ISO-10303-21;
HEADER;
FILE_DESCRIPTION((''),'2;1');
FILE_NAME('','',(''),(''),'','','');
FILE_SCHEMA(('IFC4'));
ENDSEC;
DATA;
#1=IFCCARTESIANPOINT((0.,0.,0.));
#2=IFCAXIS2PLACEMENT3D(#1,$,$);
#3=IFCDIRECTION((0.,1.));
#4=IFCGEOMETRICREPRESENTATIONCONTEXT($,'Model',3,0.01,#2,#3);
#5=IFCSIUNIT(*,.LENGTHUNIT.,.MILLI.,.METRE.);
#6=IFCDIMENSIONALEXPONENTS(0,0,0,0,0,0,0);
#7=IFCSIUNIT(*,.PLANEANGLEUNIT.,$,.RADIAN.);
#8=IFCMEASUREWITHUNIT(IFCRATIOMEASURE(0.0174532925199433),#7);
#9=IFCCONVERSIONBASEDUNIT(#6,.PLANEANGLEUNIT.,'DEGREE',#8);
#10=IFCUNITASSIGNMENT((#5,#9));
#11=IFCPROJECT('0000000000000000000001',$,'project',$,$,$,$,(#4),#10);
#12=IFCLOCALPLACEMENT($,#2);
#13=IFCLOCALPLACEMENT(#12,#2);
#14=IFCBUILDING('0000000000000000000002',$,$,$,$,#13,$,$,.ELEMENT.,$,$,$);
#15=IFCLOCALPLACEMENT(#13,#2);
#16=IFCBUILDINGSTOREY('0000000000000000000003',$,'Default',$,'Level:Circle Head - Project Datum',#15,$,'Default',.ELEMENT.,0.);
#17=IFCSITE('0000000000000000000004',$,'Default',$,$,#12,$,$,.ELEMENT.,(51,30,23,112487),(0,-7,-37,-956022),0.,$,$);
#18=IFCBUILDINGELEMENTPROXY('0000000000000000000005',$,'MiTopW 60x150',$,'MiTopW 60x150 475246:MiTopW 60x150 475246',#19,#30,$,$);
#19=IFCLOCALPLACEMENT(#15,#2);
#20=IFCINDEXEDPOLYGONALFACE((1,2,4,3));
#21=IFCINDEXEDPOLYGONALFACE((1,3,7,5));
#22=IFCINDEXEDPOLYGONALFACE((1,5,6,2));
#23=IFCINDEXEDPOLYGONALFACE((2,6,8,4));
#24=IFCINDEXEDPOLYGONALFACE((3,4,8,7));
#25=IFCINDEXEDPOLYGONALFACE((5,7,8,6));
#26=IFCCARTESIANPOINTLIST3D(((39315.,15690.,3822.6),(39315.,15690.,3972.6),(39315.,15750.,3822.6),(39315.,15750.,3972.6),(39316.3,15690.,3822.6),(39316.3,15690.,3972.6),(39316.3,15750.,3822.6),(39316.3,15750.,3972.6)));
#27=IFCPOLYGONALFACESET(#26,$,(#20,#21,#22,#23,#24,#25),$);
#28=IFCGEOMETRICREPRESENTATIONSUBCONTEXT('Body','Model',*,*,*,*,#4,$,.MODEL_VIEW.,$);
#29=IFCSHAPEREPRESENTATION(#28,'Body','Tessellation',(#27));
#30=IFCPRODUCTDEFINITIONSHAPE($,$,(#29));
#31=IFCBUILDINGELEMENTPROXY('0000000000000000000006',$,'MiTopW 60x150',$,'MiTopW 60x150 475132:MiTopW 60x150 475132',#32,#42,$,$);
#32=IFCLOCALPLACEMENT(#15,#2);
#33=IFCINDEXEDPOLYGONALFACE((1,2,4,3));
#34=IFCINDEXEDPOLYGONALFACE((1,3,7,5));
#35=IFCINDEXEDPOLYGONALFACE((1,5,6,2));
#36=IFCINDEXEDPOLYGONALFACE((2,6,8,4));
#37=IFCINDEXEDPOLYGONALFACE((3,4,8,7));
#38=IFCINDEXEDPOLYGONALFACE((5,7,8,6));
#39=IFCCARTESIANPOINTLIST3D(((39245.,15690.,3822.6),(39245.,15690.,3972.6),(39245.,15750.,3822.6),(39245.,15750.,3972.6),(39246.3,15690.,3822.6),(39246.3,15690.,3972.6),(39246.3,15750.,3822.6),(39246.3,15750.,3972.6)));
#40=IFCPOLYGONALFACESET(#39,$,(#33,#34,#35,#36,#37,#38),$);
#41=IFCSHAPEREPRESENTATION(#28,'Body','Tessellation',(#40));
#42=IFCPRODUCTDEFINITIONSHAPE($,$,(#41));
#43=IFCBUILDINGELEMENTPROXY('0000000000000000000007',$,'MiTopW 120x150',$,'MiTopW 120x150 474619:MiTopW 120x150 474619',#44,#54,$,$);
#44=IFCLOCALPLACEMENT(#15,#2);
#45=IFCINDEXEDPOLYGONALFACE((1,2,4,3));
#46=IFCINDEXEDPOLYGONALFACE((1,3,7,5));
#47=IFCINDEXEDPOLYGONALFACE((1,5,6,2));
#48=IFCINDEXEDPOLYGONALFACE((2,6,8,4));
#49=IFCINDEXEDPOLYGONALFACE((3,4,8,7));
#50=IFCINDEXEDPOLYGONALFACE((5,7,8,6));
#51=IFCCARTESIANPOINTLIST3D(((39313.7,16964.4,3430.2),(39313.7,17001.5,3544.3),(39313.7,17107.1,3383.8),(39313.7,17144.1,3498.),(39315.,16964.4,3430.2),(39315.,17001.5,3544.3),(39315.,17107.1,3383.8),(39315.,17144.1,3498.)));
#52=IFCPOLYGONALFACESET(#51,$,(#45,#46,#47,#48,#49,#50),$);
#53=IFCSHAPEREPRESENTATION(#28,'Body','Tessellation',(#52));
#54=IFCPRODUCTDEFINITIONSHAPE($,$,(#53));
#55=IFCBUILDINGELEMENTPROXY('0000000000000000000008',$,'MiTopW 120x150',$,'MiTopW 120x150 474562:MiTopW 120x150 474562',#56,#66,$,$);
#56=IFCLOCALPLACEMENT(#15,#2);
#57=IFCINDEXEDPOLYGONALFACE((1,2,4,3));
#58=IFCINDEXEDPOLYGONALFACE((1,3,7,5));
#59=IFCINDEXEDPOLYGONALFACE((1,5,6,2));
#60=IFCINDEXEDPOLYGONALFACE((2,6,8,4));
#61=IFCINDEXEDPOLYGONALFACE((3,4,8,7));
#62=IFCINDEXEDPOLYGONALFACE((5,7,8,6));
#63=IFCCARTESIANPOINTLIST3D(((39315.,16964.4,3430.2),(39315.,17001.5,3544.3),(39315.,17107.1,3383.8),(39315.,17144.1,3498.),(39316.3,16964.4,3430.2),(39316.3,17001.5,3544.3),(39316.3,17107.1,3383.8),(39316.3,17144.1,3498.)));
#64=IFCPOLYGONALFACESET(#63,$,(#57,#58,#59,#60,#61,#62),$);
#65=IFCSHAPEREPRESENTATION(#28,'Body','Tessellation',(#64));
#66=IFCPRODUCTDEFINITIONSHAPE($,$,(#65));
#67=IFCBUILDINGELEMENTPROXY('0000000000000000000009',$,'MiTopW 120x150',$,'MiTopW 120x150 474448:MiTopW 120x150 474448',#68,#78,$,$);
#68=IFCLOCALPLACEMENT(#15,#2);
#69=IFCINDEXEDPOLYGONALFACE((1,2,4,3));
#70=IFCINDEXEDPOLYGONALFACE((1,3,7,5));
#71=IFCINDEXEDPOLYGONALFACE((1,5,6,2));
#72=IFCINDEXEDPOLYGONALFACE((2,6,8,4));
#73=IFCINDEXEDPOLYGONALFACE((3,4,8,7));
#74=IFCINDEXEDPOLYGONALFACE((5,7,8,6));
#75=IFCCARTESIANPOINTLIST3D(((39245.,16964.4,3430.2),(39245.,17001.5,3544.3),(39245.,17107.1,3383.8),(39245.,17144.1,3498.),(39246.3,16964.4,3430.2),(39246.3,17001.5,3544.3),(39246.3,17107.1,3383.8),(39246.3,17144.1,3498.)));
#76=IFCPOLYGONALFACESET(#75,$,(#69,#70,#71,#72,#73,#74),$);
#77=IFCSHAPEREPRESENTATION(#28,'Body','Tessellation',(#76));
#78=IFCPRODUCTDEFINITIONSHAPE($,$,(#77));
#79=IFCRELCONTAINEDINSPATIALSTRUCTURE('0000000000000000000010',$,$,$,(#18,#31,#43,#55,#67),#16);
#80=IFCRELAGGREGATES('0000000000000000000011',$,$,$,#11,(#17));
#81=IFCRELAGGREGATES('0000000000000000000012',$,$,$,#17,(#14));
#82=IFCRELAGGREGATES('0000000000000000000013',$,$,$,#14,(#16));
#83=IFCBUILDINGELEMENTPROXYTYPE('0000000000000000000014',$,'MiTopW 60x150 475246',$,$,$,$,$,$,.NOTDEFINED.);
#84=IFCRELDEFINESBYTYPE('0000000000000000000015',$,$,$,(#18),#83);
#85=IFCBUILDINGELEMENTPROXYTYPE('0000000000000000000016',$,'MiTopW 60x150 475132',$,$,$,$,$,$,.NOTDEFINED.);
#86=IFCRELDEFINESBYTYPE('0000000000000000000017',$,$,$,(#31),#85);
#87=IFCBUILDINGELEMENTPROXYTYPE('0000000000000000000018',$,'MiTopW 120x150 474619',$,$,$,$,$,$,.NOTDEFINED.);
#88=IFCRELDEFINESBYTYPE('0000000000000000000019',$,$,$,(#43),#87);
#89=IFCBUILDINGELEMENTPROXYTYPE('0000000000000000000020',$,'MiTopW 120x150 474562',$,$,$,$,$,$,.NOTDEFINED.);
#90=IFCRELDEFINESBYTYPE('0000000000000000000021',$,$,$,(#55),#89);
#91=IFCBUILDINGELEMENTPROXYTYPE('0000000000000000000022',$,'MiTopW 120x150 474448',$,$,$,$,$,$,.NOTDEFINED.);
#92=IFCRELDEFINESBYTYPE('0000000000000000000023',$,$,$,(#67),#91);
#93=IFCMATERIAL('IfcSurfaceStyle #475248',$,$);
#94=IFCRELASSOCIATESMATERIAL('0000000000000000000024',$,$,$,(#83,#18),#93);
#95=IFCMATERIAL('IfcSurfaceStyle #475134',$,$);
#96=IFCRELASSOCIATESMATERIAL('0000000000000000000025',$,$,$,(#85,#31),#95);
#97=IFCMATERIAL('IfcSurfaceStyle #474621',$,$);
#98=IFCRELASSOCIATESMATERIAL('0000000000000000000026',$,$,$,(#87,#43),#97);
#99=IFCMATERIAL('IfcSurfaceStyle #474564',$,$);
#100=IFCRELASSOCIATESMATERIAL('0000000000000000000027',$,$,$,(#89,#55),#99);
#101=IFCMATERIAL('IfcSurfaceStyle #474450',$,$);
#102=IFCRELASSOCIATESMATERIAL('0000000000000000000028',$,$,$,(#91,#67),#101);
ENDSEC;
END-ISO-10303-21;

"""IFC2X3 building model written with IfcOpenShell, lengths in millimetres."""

from ifc_helpers import new_model, entity, si_unit, converted_unit, direction, frame, origin, origin_2d_with_axis, place, context, subcontext, project, spatial, polyline, rectangle, outline, extrude, source, transform, mapped, material, type_object, type_shapes, element, save


model = new_model("IFC2X3")

# Units and contexts
model_context = context("Model", 3, precision=0.01, world=origin(), true_north=direction((0.0, 1.0)))
body_context = subcontext(model_context, "Body", "Model", "MODEL_VIEW")
ifc_project = project(units=[si_unit("LENGTHUNIT", "METRE", prefix="MILLI"), converted_unit("PLANEANGLEUNIT", "DEGREE", entity("IfcRatioMeasure", 0.0174532925199433), si_unit("PLANEANGLEUNIT", "RADIAN"), dimensions=[0, 0, 0, 0, 0, 0, 0])], contexts=[model_context])

# Site, building, storey
site_placement = place(None, origin())
site = spatial("IfcSite", under=ifc_project, at=site_placement, Name="Default", CompositionType="ELEMENT", RefLatitude=(51, 30, 23, 112487), RefLongitude=(0, -7, -37, -956022), RefElevation=0.0)
building_placement = place(site_placement, origin())
building = spatial("IfcBuilding", under=site, at=building_placement, CompositionType="ELEMENT")
storey_placement = place(building_placement, origin())
storey = spatial("IfcBuildingStorey", under=building, at=storey_placement, Name="Default", ObjectType="Level:Circle Head - Project Datum", LongName="Default", CompositionType="ELEMENT", Elevation=0.0)

# Building element proxies
ifc_material_1 = material(Name="IfcSurfaceStyle #475248")
building_element_proxy_type_1 = type_object("IfcBuildingElementProxyType", Name="MiTopW 60x150 475246", PredefinedType="NOTDEFINED", material=ifc_material_1)
shared_shape_1 = source(origin(), body_context, "Body", "SweptSolid", [
    extrude(rectangle(XDim=150.0, YDim=60.0, at=origin_2d_with_axis()), frame((75.0, 30.0, 0.0), z_axis=(0.0, 0.0, 1.0), x_axis=(-1.0, 0.0, 0.0)), (0.0, 0.0, 1.0), 1.3),
])
type_shapes(building_element_proxy_type_1, [shared_shape_1])
proxy_1_placement = place(building_placement, frame((39316.3, 15750.0, 3972.6), z_axis=(-1.0, 0.0, 0.0), x_axis=(0.0, 0.0, -1.0)))
element("IfcBuildingElementProxy", 1, at=proxy_1_placement, inside=storey, type_object=building_element_proxy_type_1, material=ifc_material_1, Name="MiTopW 60x150", ObjectType="MiTopW 60x150 475246:MiTopW 60x150 475246", context=body_context, shape_type="MappedRepresentation", body=[
    mapped(shared_shape_1, transform((0.0, 0.0, 0.0), scale=1.0)),
])
ifc_material_2 = material(Name="IfcSurfaceStyle #475134")
building_element_proxy_type_2 = type_object("IfcBuildingElementProxyType", Name="MiTopW 60x150 475132", PredefinedType="NOTDEFINED", material=ifc_material_2)
shared_shape_2 = source(origin(), body_context, "Body", "SweptSolid", [
    extrude(rectangle(XDim=150.0, YDim=60.0, at=origin_2d_with_axis()), frame((75.0, 30.0, 0.0), z_axis=(0.0, 0.0, 1.0), x_axis=(-1.0, 0.0, 0.0)), (0.0, 0.0, 1.0), 1.3),
])
type_shapes(building_element_proxy_type_2, [shared_shape_2])
proxy_2_placement = place(building_placement, frame((39246.3, 15750.0, 3972.6), z_axis=(-1.0, 0.0, 0.0), x_axis=(0.0, 0.0, -1.0)))
element("IfcBuildingElementProxy", 2, at=proxy_2_placement, inside=storey, type_object=building_element_proxy_type_2, material=ifc_material_2, Name="MiTopW 60x150", ObjectType="MiTopW 60x150 475132:MiTopW 60x150 475132", context=body_context, shape_type="MappedRepresentation", body=[
    mapped(shared_shape_2, transform((0.0, 0.0, 0.0), scale=1.0)),
])
ifc_material_3 = material(Name="IfcSurfaceStyle #474621")
building_element_proxy_type_3 = type_object("IfcBuildingElementProxyType", Name="MiTopW 120x150 474619", PredefinedType="NOTDEFINED", material=ifc_material_3)
shared_shape_3 = source(origin(), body_context, "Body", "SweptSolid", [
    extrude(outline(polyline([(-75.0, -60.0), (75.0, -60.0), (75.0, 60.0), (-75.0, 60.0), (-75.0, -60.0)])), frame((75.0, 60.0, 0.0), z_axis=(0.0, 0.0, 1.0), x_axis=(-1.0, 0.0, 0.0)), (0.0, 0.0, 1.0), 1.3),
])
type_shapes(building_element_proxy_type_3, [shared_shape_3])
proxy_3_placement = place(building_placement, frame((39315.0, 17107.1, 3383.8), z_axis=(-1.0, 0.0, 0.0), x_axis=(0.0, -0.951057, 0.309017)))
element("IfcBuildingElementProxy", 3, at=proxy_3_placement, inside=storey, type_object=building_element_proxy_type_3, material=ifc_material_3, Name="MiTopW 120x150", ObjectType="MiTopW 120x150 474619:MiTopW 120x150 474619", context=body_context, shape_type="MappedRepresentation", body=[
    mapped(shared_shape_3, transform((0.0, 0.0, 0.0), scale=1.0)),
])
ifc_material_4 = material(Name="IfcSurfaceStyle #474564")
building_element_proxy_type_4 = type_object("IfcBuildingElementProxyType", Name="MiTopW 120x150 474562", PredefinedType="NOTDEFINED", material=ifc_material_4)
shared_shape_4 = source(origin(), body_context, "Body", "SweptSolid", [
    extrude(outline(polyline([(-75.0, -60.0), (75.0, -60.0), (75.0, 60.0), (-75.0, 60.0), (-75.0, -60.0)])), frame((75.0, 60.0, 0.0), z_axis=(0.0, 0.0, 1.0), x_axis=(-1.0, 0.0, 0.0)), (0.0, 0.0, 1.0), 1.3),
])
type_shapes(building_element_proxy_type_4, [shared_shape_4])
proxy_4_placement = place(building_placement, frame((39316.3, 17107.1, 3383.8), z_axis=(-1.0, 0.0, 0.0), x_axis=(0.0, -0.951057, 0.309017)))
element("IfcBuildingElementProxy", 4, at=proxy_4_placement, inside=storey, type_object=building_element_proxy_type_4, material=ifc_material_4, Name="MiTopW 120x150", ObjectType="MiTopW 120x150 474562:MiTopW 120x150 474562", context=body_context, shape_type="MappedRepresentation", body=[
    mapped(shared_shape_4, transform((0.0, 0.0, 0.0), scale=1.0)),
])
ifc_material_5 = material(Name="IfcSurfaceStyle #474450")
building_element_proxy_type_5 = type_object("IfcBuildingElementProxyType", Name="MiTopW 120x150 474448", PredefinedType="NOTDEFINED", material=ifc_material_5)
shared_shape_5 = source(origin(), body_context, "Body", "SweptSolid", [
    extrude(outline(polyline([(-75.0, -60.0), (75.0, -60.0), (75.0, 60.0), (-75.0, 60.0), (-75.0, -60.0)])), frame((75.0, 60.0, 0.0), z_axis=(0.0, 0.0, 1.0), x_axis=(-1.0, 0.0, 0.0)), (0.0, 0.0, 1.0), 1.3),
])
type_shapes(building_element_proxy_type_5, [shared_shape_5])
proxy_5_placement = place(building_placement, frame((39246.3, 17107.1, 3383.8), z_axis=(-1.0, 0.0, 0.0), x_axis=(0.0, -0.951057, 0.309017)))
element("IfcBuildingElementProxy", 5, at=proxy_5_placement, inside=storey, type_object=building_element_proxy_type_5, material=ifc_material_5, Name="MiTopW 120x150", ObjectType="MiTopW 120x150 474448:MiTopW 120x150 474448", context=body_context, shape_type="MappedRepresentation", body=[
    mapped(shared_shape_5, transform((0.0, 0.0, 0.0), scale=1.0)),
])

save(model, "model.ifc")
